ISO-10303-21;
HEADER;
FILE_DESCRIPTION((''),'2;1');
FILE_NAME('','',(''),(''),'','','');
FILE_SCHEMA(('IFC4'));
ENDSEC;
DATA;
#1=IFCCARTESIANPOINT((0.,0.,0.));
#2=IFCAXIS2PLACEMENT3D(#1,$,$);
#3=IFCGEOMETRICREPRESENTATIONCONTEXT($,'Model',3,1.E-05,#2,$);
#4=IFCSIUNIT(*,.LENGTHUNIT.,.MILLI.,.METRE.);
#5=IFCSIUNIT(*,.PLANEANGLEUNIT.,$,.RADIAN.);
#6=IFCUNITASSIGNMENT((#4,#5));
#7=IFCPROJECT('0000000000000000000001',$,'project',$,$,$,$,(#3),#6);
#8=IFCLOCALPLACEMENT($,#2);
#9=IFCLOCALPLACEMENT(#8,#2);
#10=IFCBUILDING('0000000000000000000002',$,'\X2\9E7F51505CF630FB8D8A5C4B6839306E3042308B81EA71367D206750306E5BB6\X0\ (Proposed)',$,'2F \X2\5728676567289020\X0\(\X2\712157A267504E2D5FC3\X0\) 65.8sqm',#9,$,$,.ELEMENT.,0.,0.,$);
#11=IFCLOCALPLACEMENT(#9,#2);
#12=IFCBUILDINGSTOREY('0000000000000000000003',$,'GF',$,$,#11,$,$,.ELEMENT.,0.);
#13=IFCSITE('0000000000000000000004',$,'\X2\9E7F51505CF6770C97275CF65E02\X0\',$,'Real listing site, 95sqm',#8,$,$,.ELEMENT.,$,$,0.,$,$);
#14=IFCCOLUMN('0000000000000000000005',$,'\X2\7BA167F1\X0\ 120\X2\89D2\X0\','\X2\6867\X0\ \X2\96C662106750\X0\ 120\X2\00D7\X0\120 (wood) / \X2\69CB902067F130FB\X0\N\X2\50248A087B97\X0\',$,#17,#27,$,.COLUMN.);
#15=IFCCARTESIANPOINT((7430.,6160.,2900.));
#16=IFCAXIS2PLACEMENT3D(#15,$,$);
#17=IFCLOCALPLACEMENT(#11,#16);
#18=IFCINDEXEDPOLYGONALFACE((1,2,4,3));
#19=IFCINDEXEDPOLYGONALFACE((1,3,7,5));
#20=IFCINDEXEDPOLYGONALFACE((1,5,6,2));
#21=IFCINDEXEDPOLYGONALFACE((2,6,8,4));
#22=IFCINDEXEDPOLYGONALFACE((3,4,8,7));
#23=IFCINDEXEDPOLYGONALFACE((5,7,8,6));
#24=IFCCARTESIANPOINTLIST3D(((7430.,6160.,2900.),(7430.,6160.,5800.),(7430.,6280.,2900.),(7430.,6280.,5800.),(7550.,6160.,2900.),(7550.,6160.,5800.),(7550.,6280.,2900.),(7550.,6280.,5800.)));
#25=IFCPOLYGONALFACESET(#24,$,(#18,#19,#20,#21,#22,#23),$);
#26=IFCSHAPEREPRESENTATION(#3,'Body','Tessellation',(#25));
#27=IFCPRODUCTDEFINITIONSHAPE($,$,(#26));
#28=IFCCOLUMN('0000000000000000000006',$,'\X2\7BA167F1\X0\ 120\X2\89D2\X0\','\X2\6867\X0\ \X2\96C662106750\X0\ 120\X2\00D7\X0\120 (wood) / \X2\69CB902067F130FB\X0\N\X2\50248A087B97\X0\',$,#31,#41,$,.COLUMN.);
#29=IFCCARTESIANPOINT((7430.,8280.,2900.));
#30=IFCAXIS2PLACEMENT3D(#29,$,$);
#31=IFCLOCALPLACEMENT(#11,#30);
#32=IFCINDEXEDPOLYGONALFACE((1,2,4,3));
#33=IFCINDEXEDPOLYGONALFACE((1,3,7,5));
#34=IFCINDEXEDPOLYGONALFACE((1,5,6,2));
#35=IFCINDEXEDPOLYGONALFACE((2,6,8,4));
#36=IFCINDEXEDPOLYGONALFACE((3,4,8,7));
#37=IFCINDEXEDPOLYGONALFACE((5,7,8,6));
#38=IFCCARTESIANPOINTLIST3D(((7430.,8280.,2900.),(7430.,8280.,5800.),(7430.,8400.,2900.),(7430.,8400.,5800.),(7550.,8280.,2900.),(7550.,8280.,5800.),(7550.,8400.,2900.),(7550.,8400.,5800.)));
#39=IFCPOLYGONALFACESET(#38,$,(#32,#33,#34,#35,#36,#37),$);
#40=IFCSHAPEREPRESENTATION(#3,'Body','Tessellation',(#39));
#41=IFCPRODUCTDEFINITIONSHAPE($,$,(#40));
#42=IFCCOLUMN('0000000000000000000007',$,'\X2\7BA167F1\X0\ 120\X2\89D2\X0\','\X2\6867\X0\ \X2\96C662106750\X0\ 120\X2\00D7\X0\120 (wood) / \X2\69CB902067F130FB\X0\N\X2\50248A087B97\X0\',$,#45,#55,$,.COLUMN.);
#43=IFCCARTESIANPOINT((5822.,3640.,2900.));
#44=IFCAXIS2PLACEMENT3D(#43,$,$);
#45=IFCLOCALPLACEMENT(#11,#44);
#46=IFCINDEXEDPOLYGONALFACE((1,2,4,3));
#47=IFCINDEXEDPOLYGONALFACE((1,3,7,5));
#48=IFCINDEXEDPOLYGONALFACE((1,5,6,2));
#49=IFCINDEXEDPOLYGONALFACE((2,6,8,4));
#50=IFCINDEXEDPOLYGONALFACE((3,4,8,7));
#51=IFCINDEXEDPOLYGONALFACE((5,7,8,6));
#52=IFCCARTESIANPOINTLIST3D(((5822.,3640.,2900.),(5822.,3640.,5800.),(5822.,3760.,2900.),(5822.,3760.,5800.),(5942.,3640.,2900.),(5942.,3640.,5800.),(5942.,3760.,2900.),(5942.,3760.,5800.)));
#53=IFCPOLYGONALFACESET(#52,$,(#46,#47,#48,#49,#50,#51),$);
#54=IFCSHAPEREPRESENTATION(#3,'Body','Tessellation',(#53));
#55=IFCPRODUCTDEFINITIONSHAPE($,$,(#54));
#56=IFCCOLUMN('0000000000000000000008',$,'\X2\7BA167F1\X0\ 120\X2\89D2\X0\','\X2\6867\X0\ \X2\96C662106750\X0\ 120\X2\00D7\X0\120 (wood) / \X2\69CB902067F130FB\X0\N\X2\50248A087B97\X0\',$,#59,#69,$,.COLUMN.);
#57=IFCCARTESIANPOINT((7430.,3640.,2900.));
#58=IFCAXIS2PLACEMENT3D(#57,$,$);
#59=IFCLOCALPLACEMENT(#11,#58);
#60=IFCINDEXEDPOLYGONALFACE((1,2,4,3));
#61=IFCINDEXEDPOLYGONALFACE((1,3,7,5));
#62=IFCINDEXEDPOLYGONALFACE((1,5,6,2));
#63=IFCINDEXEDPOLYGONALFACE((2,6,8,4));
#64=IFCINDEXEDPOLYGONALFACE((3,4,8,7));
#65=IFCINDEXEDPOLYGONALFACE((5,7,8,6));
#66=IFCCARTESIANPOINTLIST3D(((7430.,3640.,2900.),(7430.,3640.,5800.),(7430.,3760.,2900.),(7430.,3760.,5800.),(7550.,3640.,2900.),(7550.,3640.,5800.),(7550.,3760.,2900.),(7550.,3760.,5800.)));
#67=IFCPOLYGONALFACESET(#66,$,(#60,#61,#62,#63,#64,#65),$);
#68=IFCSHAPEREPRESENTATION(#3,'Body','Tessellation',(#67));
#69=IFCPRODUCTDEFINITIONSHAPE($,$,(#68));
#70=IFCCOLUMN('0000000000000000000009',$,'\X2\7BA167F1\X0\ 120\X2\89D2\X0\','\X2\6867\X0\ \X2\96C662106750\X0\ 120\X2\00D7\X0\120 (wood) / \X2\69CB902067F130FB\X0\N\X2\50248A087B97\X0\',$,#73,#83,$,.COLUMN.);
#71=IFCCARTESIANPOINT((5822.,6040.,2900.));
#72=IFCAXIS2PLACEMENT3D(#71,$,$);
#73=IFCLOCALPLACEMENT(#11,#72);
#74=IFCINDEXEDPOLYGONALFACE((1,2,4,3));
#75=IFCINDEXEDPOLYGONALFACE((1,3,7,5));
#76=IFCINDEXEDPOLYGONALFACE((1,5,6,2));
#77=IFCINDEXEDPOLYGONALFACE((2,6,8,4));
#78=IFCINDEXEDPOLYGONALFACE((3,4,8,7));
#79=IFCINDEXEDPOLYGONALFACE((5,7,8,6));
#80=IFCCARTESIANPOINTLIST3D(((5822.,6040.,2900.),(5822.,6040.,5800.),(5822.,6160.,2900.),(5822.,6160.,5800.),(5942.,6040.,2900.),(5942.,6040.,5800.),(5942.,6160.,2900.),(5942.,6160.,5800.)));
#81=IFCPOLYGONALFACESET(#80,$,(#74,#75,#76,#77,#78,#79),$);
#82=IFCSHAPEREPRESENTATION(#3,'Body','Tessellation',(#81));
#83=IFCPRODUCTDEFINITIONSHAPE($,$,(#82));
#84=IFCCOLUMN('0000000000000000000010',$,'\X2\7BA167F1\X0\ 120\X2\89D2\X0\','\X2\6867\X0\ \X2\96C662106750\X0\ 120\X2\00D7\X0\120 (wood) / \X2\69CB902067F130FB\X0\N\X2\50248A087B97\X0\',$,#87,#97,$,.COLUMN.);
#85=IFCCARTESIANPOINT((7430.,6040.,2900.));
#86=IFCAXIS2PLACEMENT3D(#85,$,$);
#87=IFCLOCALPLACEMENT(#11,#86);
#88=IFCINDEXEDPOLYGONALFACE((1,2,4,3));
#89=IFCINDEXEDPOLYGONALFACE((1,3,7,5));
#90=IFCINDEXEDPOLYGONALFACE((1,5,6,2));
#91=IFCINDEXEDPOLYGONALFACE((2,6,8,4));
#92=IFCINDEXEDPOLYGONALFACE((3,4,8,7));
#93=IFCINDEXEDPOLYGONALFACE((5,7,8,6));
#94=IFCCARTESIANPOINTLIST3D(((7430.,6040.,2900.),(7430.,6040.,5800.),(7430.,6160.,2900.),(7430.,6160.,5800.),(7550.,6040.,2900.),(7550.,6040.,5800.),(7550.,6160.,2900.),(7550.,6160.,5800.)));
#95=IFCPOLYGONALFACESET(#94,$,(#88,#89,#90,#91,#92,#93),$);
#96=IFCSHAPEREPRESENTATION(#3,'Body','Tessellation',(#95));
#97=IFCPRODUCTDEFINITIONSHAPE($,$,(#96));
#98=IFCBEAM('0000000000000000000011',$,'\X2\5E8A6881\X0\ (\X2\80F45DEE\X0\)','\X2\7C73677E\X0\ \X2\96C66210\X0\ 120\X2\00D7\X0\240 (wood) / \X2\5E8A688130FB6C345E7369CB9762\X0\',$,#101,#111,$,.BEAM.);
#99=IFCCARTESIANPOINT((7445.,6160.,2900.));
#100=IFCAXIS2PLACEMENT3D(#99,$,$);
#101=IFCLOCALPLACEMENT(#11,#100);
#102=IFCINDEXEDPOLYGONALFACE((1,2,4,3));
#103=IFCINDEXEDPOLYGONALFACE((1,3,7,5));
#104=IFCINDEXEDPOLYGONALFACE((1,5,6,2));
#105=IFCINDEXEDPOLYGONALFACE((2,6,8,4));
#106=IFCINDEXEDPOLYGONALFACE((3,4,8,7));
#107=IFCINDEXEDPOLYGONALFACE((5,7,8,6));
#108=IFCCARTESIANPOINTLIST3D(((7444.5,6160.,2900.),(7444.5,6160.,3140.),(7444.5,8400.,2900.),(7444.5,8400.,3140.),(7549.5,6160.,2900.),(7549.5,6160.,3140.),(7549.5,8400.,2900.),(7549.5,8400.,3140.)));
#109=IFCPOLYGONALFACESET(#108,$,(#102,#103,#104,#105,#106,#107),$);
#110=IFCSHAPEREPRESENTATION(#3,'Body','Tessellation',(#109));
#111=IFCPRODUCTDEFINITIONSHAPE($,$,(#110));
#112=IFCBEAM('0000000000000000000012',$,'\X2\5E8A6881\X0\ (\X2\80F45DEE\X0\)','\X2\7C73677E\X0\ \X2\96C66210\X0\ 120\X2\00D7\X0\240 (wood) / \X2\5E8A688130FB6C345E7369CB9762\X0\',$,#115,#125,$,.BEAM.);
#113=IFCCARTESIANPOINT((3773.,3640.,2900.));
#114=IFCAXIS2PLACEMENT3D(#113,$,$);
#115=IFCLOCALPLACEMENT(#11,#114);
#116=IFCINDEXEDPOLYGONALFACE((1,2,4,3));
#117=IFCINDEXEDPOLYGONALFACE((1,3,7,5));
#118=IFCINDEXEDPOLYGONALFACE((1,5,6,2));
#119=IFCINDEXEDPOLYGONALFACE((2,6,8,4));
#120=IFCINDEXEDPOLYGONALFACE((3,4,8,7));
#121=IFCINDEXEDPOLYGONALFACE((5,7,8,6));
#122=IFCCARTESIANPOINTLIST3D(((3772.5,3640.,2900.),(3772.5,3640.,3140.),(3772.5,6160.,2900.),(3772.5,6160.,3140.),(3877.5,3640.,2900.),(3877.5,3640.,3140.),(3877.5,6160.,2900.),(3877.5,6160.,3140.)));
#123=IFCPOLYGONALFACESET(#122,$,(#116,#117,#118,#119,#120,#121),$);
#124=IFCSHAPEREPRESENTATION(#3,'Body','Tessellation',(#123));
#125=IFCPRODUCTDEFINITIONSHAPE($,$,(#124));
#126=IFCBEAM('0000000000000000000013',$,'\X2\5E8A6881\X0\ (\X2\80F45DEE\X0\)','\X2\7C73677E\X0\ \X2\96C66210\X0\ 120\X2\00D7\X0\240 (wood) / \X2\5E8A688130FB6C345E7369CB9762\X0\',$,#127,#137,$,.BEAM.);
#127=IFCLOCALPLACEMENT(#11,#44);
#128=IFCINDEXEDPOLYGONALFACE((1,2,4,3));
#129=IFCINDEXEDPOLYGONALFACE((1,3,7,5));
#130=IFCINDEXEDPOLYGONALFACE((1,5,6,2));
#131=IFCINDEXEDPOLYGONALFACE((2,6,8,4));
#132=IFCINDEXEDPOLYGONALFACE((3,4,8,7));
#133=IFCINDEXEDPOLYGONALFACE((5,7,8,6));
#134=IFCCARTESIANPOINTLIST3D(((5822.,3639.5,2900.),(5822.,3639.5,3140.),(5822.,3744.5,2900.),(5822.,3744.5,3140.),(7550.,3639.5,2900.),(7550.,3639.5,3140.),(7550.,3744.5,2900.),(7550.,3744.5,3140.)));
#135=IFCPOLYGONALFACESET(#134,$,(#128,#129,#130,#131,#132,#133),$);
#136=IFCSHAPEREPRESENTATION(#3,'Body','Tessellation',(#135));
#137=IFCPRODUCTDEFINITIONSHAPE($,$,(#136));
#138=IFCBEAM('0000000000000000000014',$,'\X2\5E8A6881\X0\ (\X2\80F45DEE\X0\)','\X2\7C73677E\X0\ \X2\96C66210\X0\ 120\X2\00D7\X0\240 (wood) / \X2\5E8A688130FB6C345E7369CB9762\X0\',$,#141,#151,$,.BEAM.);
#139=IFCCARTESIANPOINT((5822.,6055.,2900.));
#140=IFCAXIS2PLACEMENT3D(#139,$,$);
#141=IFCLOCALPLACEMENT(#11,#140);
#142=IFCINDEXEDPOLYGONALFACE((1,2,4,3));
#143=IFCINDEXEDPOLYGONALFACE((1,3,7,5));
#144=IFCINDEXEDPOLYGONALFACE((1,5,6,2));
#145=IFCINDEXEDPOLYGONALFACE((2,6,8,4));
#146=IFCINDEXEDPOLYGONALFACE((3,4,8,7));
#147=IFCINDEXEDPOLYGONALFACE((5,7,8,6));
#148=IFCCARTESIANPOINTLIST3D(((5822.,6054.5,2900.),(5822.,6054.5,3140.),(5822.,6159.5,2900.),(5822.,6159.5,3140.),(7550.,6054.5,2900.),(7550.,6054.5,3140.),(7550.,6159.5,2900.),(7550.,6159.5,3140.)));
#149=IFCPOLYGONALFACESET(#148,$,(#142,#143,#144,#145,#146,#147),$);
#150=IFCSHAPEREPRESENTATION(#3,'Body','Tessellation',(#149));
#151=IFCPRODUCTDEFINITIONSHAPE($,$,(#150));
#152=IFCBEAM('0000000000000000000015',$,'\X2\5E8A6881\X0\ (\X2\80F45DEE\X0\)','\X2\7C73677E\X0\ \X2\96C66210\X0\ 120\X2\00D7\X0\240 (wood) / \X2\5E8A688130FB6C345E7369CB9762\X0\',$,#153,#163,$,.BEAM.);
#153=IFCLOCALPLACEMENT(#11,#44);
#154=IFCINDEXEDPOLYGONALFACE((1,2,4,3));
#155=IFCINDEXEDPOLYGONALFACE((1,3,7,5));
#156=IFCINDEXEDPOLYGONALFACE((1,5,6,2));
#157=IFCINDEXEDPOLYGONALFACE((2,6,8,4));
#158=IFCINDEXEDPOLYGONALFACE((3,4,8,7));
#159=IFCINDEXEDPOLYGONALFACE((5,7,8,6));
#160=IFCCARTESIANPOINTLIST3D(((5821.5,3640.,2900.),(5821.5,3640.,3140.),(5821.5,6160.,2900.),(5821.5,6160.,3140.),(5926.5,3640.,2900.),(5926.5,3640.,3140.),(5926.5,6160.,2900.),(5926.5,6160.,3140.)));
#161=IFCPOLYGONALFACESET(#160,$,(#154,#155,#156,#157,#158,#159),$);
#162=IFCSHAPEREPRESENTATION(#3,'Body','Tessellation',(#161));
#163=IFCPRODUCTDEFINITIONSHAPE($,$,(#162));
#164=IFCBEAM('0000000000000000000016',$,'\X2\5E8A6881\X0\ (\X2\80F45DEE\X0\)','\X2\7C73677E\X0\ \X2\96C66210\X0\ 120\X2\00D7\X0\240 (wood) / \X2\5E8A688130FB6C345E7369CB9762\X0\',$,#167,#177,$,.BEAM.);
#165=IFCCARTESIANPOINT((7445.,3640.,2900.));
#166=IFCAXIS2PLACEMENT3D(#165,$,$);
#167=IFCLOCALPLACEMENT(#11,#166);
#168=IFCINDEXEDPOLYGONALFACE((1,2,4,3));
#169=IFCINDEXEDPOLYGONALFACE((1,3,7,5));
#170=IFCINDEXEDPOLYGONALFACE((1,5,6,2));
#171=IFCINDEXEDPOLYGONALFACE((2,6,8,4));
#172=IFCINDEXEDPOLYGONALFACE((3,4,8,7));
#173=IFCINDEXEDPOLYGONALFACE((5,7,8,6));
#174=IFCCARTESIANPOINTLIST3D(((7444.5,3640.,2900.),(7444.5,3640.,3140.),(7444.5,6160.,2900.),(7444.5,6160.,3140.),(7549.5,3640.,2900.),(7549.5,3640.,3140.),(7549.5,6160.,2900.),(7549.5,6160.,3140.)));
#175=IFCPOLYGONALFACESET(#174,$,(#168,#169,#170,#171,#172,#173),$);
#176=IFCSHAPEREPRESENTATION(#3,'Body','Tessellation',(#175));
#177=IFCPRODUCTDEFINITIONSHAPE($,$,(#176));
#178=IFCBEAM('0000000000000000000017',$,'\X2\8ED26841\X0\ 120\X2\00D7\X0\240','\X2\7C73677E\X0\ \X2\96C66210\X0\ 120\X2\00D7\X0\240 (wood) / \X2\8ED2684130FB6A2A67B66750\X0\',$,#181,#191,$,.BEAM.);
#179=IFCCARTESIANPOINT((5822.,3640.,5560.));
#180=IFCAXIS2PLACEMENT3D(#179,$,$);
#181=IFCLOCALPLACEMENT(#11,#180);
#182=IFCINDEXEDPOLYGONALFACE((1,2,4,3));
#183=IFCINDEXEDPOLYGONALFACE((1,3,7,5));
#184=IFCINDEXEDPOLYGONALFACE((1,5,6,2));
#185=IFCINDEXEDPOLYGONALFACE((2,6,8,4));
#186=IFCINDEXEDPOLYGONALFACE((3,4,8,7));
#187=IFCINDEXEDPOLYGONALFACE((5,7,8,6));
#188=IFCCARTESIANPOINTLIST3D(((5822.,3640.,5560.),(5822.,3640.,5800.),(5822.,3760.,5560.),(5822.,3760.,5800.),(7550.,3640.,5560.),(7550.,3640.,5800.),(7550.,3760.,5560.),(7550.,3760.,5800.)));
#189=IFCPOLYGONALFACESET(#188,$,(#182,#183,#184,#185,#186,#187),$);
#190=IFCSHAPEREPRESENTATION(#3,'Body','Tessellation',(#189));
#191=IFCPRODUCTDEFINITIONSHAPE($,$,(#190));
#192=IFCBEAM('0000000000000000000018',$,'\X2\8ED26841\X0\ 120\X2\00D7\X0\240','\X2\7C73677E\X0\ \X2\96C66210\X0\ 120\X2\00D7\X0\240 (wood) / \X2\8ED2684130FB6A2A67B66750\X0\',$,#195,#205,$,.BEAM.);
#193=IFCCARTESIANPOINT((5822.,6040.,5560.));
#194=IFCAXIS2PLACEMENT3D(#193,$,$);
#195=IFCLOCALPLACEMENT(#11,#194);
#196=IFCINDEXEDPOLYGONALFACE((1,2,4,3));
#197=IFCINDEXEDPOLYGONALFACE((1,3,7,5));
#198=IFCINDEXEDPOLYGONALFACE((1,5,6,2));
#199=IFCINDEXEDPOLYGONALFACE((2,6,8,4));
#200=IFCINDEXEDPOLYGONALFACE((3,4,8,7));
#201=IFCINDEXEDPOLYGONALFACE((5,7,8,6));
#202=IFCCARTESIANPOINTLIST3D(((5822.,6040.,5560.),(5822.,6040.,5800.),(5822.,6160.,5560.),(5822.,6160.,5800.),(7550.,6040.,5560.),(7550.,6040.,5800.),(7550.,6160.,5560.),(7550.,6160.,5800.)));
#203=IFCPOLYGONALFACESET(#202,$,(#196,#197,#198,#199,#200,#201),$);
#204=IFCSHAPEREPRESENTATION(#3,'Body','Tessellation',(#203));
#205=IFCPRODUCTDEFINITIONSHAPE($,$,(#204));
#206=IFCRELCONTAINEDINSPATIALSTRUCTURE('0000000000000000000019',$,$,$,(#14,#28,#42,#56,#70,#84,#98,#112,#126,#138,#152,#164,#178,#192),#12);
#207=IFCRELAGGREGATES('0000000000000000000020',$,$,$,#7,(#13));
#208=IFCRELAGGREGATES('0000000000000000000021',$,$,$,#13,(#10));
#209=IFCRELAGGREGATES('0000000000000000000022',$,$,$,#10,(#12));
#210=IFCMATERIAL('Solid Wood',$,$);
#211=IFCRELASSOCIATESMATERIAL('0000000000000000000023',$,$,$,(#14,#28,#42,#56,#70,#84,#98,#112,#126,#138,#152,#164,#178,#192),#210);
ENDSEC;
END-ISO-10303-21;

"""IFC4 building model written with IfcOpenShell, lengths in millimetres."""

from ifc_helpers import new_model, si_unit, frame, frame_2d, origin, place, context, project, spatial, rectangle, extrude, material, element, save


model = new_model("IFC4")

# Units and contexts
model_context = context("Model", 3, precision=1e-05, world=origin())
ifc_project = project(units=[si_unit("LENGTHUNIT", "METRE", prefix="MILLI"), si_unit("PLANEANGLEUNIT", "RADIAN")], contexts=[model_context])

# Site, building, storey
site_placement = place(None, origin())
site = spatial("IfcSite", under=ifc_project, at=site_placement, Name="鹿児島県霧島市", ObjectType="Real listing site, 95sqm", CompositionType="ELEMENT", RefElevation=0.0)
building_placement = place(site_placement, origin())
building = spatial("IfcBuilding", under=site, at=building_placement, Name="鹿児島・越屋根のある自然素材の家 (Proposed)", ObjectType="2F 在来木造(無垢材中心) 65.8sqm", CompositionType="ELEMENT", ElevationOfRefHeight=0.0, ElevationOfTerrain=0.0)
storey_placement = place(building_placement, origin())
storey = spatial("IfcBuildingStorey", under=building, at=storey_placement, Name="GF", CompositionType="ELEMENT", Elevation=0.0)

# Columns
ifc_material_1 = material(Name="Solid Wood")
column_1_placement = place(storey_placement, frame((7430.0, 6160.0, 2900.0)))
element("IfcColumn", 1, at=column_1_placement, inside=storey, material=ifc_material_1, Name="管柱 120角", Description="桧 集成材 120×120 (wood) / 構造柱・N値計算", PredefinedType="COLUMN", context=model_context, shape_type="SweptSolid", body=[
    extrude(rectangle(XDim=120.0, YDim=120.0, at=frame_2d((60.0, 60.0))), frame((7430.0, 6160.0, 2900.0)), (0.0, 0.0, 1.0), 2900.0),
])
column_2_placement = place(storey_placement, frame((7430.0, 8280.0, 2900.0)))
element("IfcColumn", 2, at=column_2_placement, inside=storey, material=ifc_material_1, Name="管柱 120角", Description="桧 集成材 120×120 (wood) / 構造柱・N値計算", PredefinedType="COLUMN", context=model_context, shape_type="SweptSolid", body=[
    extrude(rectangle(XDim=120.0, YDim=120.0, at=frame_2d((60.0, 60.0))), frame((7430.0, 8280.0, 2900.0)), (0.0, 0.0, 1.0), 2900.0),
])
column_3_placement = place(storey_placement, frame((5822.0, 3640.0, 2900.0)))
element("IfcColumn", 3, at=column_3_placement, inside=storey, material=ifc_material_1, Name="管柱 120角", Description="桧 集成材 120×120 (wood) / 構造柱・N値計算", PredefinedType="COLUMN", context=model_context, shape_type="SweptSolid", body=[
    extrude(rectangle(XDim=120.0, YDim=120.0, at=frame_2d((60.0, 60.0))), frame((5822.0, 3640.0, 2900.0)), (0.0, 0.0, 1.0), 2900.0),
])
column_4_placement = place(storey_placement, frame((7430.0, 3640.0, 2900.0)))
element("IfcColumn", 4, at=column_4_placement, inside=storey, material=ifc_material_1, Name="管柱 120角", Description="桧 集成材 120×120 (wood) / 構造柱・N値計算", PredefinedType="COLUMN", context=model_context, shape_type="SweptSolid", body=[
    extrude(rectangle(XDim=120.0, YDim=120.0, at=frame_2d((60.0, 60.0))), frame((7430.0, 3640.0, 2900.0)), (0.0, 0.0, 1.0), 2900.0),
])
column_5_placement = place(storey_placement, frame((5822.0, 6040.0, 2900.0)))
element("IfcColumn", 5, at=column_5_placement, inside=storey, material=ifc_material_1, Name="管柱 120角", Description="桧 集成材 120×120 (wood) / 構造柱・N値計算", PredefinedType="COLUMN", context=model_context, shape_type="SweptSolid", body=[
    extrude(rectangle(XDim=120.0, YDim=120.0, at=frame_2d((60.0, 60.0))), frame((5822.0, 6040.0, 2900.0)), (0.0, 0.0, 1.0), 2900.0),
])
column_6_placement = place(storey_placement, frame((7430.0, 6040.0, 2900.0)))
element("IfcColumn", 6, at=column_6_placement, inside=storey, material=ifc_material_1, Name="管柱 120角", Description="桧 集成材 120×120 (wood) / 構造柱・N値計算", PredefinedType="COLUMN", context=model_context, shape_type="SweptSolid", body=[
    extrude(rectangle(XDim=120.0, YDim=120.0, at=frame_2d((60.0, 60.0))), frame((7430.0, 6040.0, 2900.0)), (0.0, 0.0, 1.0), 2900.0),
])

# Beams
beam_1_placement = place(storey_placement, frame((7445.0, 6160.0, 2900.0)))
element("IfcBeam", 7, at=beam_1_placement, inside=storey, material=ifc_material_1, Name="床梁 (胴差)", Description="米松 集成 120×240 (wood) / 床梁・水平構面", PredefinedType="BEAM", context=model_context, shape_type="SweptSolid", body=[
    extrude(rectangle(XDim=105.0, YDim=2240.0, at=frame_2d((52.0, 1120.0))), frame((7445.0, 6160.0, 2900.0)), (0.0, 0.0, 1.0), 240.0),
])
beam_2_placement = place(storey_placement, frame((3773.0, 3640.0, 2900.0)))
element("IfcBeam", 8, at=beam_2_placement, inside=storey, material=ifc_material_1, Name="床梁 (胴差)", Description="米松 集成 120×240 (wood) / 床梁・水平構面", PredefinedType="BEAM", context=model_context, shape_type="SweptSolid", body=[
    extrude(rectangle(XDim=105.0, YDim=2520.0, at=frame_2d((52.0, 1260.0))), frame((3773.0, 3640.0, 2900.0)), (0.0, 0.0, 1.0), 240.0),
])
beam_3_placement = place(storey_placement, frame((5822.0, 3640.0, 2900.0)))
element("IfcBeam", 9, at=beam_3_placement, inside=storey, material=ifc_material_1, Name="床梁 (胴差)", Description="米松 集成 120×240 (wood) / 床梁・水平構面", PredefinedType="BEAM", context=model_context, shape_type="SweptSolid", body=[
    extrude(rectangle(XDim=1728.0, YDim=105.0, at=frame_2d((864.0, 52.0))), frame((5822.0, 3640.0, 2900.0)), (0.0, 0.0, 1.0), 240.0),
])
beam_4_placement = place(storey_placement, frame((5822.0, 6055.0, 2900.0)))
element("IfcBeam", 10, at=beam_4_placement, inside=storey, material=ifc_material_1, Name="床梁 (胴差)", Description="米松 集成 120×240 (wood) / 床梁・水平構面", PredefinedType="BEAM", context=model_context, shape_type="SweptSolid", body=[
    extrude(rectangle(XDim=1728.0, YDim=105.0, at=frame_2d((864.0, 52.0))), frame((5822.0, 6055.0, 2900.0)), (0.0, 0.0, 1.0), 240.0),
])
beam_5_placement = place(storey_placement, frame((5822.0, 3640.0, 2900.0)))
element("IfcBeam", 11, at=beam_5_placement, inside=storey, material=ifc_material_1, Name="床梁 (胴差)", Description="米松 集成 120×240 (wood) / 床梁・水平構面", PredefinedType="BEAM", context=model_context, shape_type="SweptSolid", body=[
    extrude(rectangle(XDim=105.0, YDim=2520.0, at=frame_2d((52.0, 1260.0))), frame((5822.0, 3640.0, 2900.0)), (0.0, 0.0, 1.0), 240.0),
])
beam_6_placement = place(storey_placement, frame((7445.0, 3640.0, 2900.0)))
element("IfcBeam", 12, at=beam_6_placement, inside=storey, material=ifc_material_1, Name="床梁 (胴差)", Description="米松 集成 120×240 (wood) / 床梁・水平構面", PredefinedType="BEAM", context=model_context, shape_type="SweptSolid", body=[
    extrude(rectangle(XDim=105.0, YDim=2520.0, at=frame_2d((52.0, 1260.0))), frame((7445.0, 3640.0, 2900.0)), (0.0, 0.0, 1.0), 240.0),
])
beam_7_placement = place(storey_placement, frame((5822.0, 3640.0, 5560.0)))
element("IfcBeam", 13, at=beam_7_placement, inside=storey, material=ifc_material_1, Name="軒桁 120×240", Description="米松 集成 120×240 (wood) / 軒桁・横架材", PredefinedType="BEAM", context=model_context, shape_type="SweptSolid", body=[
    extrude(rectangle(XDim=1728.0, YDim=120.0, at=frame_2d((864.0, 60.0))), frame((5822.0, 3640.0, 5560.0)), (0.0, 0.0, 1.0), 240.0),
])
beam_8_placement = place(storey_placement, frame((5822.0, 6040.0, 5560.0)))
element("IfcBeam", 14, at=beam_8_placement, inside=storey, material=ifc_material_1, Name="軒桁 120×240", Description="米松 集成 120×240 (wood) / 軒桁・横架材", PredefinedType="BEAM", context=model_context, shape_type="SweptSolid", body=[
    extrude(rectangle(XDim=1728.0, YDim=120.0, at=frame_2d((864.0, 60.0))), frame((5822.0, 6040.0, 5560.0)), (0.0, 0.0, 1.0), 240.0),
])

save(model, "model.ifc")
